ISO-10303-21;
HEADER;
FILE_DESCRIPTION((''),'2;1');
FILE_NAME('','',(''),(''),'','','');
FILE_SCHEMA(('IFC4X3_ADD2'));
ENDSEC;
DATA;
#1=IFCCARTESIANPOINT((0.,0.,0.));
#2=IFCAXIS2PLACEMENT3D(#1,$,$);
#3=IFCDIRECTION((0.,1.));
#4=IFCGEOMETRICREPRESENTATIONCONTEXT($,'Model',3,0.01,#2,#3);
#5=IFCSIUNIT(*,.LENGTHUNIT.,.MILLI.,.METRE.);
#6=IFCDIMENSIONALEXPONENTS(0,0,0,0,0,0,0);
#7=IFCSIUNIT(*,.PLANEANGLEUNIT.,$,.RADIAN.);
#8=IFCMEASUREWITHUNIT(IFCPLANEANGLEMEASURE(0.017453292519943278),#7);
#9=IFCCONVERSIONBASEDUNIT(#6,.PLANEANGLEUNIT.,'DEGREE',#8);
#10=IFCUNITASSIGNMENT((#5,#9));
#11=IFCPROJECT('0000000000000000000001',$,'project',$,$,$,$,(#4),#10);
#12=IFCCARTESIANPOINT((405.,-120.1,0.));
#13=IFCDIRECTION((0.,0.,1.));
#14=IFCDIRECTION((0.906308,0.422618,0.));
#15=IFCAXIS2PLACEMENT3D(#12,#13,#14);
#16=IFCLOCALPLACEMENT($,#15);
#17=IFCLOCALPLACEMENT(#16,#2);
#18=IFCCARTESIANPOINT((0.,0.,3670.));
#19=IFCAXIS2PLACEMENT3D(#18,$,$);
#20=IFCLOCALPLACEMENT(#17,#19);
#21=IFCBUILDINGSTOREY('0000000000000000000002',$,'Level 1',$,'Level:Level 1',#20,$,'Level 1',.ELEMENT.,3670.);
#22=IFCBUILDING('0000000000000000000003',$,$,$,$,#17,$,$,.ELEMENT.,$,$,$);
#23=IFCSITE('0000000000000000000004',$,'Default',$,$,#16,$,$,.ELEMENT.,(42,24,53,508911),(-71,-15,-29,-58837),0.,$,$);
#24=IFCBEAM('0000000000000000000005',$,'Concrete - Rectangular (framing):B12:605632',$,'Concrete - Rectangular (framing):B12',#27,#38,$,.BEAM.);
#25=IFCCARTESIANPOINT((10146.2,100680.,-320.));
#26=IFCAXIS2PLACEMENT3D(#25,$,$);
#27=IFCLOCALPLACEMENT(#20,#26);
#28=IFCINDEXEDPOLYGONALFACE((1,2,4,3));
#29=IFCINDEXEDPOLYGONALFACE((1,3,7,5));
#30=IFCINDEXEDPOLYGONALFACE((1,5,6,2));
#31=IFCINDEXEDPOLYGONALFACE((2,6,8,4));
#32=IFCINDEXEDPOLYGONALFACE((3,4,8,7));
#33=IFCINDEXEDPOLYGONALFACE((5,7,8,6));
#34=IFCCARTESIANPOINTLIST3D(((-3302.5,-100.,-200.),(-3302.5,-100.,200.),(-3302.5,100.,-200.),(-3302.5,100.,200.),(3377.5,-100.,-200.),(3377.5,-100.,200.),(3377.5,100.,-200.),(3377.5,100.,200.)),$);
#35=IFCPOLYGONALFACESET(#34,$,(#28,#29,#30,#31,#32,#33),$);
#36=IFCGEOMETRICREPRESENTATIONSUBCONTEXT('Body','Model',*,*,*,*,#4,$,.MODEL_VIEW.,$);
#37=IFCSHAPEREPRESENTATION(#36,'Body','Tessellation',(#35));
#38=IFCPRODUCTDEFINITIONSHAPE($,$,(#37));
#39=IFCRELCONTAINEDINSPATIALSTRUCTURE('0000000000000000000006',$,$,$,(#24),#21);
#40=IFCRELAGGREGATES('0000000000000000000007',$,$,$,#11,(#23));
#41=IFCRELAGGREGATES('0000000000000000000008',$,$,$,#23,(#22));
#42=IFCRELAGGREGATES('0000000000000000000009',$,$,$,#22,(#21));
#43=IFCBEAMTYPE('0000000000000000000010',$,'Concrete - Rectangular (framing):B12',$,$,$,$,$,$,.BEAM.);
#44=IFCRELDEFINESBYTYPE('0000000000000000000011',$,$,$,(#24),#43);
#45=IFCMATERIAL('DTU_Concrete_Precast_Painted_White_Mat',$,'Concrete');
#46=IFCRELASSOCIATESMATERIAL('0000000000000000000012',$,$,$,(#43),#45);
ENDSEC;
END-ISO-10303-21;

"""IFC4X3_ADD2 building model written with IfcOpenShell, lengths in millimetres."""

from ifc_helpers import new_model, entity, si_unit, converted_unit, direction, frame, origin, origin_2d_with_axis, place, context, subcontext, project, spatial, rectangle, extrude, source, transform, mapped, material, material_profile, profile_set, type_object, type_shapes, element, save


model = new_model("IFC4X3_ADD2")

# Units and contexts
model_context = context("Model", 3, precision=0.01, world=origin(), true_north=direction((0.0, 1.0)))
body_context = subcontext(model_context, "Body", "Model", "MODEL_VIEW")
ifc_project = project(units=[si_unit("LENGTHUNIT", "METRE", prefix="MILLI"), converted_unit("PLANEANGLEUNIT", "DEGREE", entity("IfcPlaneAngleMeasure", 0.017453292519943278), si_unit("PLANEANGLEUNIT", "RADIAN"), dimensions=[0, 0, 0, 0, 0, 0, 0])], contexts=[model_context])

# Site, building, storey
site_placement = place(None, frame((405.0, -120.1, 0.0), z_axis=(0.0, 0.0, 1.0), x_axis=(0.906308, 0.422618, 0.0)))
site = spatial("IfcSite", under=ifc_project, at=site_placement, Name="Default", CompositionType="ELEMENT", RefLatitude=(42, 24, 53, 508911), RefLongitude=(-71, -15, -29, -58837), RefElevation=0.0)
building_placement = place(site_placement, origin())
building = spatial("IfcBuilding", under=site, at=building_placement, CompositionType="ELEMENT")
storey_placement = place(building_placement, frame((0.0, 0.0, 3670.0)))
storey = spatial("IfcBuildingStorey", under=building, at=storey_placement, Name="Level 1", ObjectType="Level:Level 1", LongName="Level 1", CompositionType="ELEMENT", Elevation=3670.0)

# Beam
ifc_material = material(Name="DTU_Concrete_Precast_Painted_White_Mat", Category="Concrete")
ifc_material_profile_1 = material_profile(ifc_material, rectangle(XDim=6700.0, YDim=200.0, at=origin_2d_with_axis()), Name="B12")
ifc_profile_set_1 = profile_set([ifc_material_profile_1], Name="B12")
beam_type_1 = type_object("IfcBeamType", Name="Concrete - Rectangular (framing):B12", PredefinedType="BEAM", material=ifc_profile_set_1)
shared_shape_1 = source(origin(), body_context, "Body", "SweptSolid", [
    extrude(rectangle(XDim=6680.0, YDim=200.0, at=origin_2d_with_axis()), frame((37.5, 0.0, -200.0), z_axis=(0.0, 0.0, 1.0), x_axis=(-1.0, 0.0, 0.0)), (0.0, 0.0, 1.0), 400.0),
])
type_shapes(beam_type_1, [shared_shape_1])
beam_1_placement = place(storey_placement, frame((10146.2, 100680.0, -320.0)))
element("IfcBeam", 1, at=beam_1_placement, inside=storey, type_object=beam_type_1, Name="Concrete - Rectangular (framing):B12:605632", ObjectType="Concrete - Rectangular (framing):B12", PredefinedType="BEAM", context=body_context, shape_type="MappedRepresentation", body=[
    mapped(shared_shape_1, transform((0.0, 0.0, 0.0), scale=1.0)),
])

save(model, "model.ifc")
